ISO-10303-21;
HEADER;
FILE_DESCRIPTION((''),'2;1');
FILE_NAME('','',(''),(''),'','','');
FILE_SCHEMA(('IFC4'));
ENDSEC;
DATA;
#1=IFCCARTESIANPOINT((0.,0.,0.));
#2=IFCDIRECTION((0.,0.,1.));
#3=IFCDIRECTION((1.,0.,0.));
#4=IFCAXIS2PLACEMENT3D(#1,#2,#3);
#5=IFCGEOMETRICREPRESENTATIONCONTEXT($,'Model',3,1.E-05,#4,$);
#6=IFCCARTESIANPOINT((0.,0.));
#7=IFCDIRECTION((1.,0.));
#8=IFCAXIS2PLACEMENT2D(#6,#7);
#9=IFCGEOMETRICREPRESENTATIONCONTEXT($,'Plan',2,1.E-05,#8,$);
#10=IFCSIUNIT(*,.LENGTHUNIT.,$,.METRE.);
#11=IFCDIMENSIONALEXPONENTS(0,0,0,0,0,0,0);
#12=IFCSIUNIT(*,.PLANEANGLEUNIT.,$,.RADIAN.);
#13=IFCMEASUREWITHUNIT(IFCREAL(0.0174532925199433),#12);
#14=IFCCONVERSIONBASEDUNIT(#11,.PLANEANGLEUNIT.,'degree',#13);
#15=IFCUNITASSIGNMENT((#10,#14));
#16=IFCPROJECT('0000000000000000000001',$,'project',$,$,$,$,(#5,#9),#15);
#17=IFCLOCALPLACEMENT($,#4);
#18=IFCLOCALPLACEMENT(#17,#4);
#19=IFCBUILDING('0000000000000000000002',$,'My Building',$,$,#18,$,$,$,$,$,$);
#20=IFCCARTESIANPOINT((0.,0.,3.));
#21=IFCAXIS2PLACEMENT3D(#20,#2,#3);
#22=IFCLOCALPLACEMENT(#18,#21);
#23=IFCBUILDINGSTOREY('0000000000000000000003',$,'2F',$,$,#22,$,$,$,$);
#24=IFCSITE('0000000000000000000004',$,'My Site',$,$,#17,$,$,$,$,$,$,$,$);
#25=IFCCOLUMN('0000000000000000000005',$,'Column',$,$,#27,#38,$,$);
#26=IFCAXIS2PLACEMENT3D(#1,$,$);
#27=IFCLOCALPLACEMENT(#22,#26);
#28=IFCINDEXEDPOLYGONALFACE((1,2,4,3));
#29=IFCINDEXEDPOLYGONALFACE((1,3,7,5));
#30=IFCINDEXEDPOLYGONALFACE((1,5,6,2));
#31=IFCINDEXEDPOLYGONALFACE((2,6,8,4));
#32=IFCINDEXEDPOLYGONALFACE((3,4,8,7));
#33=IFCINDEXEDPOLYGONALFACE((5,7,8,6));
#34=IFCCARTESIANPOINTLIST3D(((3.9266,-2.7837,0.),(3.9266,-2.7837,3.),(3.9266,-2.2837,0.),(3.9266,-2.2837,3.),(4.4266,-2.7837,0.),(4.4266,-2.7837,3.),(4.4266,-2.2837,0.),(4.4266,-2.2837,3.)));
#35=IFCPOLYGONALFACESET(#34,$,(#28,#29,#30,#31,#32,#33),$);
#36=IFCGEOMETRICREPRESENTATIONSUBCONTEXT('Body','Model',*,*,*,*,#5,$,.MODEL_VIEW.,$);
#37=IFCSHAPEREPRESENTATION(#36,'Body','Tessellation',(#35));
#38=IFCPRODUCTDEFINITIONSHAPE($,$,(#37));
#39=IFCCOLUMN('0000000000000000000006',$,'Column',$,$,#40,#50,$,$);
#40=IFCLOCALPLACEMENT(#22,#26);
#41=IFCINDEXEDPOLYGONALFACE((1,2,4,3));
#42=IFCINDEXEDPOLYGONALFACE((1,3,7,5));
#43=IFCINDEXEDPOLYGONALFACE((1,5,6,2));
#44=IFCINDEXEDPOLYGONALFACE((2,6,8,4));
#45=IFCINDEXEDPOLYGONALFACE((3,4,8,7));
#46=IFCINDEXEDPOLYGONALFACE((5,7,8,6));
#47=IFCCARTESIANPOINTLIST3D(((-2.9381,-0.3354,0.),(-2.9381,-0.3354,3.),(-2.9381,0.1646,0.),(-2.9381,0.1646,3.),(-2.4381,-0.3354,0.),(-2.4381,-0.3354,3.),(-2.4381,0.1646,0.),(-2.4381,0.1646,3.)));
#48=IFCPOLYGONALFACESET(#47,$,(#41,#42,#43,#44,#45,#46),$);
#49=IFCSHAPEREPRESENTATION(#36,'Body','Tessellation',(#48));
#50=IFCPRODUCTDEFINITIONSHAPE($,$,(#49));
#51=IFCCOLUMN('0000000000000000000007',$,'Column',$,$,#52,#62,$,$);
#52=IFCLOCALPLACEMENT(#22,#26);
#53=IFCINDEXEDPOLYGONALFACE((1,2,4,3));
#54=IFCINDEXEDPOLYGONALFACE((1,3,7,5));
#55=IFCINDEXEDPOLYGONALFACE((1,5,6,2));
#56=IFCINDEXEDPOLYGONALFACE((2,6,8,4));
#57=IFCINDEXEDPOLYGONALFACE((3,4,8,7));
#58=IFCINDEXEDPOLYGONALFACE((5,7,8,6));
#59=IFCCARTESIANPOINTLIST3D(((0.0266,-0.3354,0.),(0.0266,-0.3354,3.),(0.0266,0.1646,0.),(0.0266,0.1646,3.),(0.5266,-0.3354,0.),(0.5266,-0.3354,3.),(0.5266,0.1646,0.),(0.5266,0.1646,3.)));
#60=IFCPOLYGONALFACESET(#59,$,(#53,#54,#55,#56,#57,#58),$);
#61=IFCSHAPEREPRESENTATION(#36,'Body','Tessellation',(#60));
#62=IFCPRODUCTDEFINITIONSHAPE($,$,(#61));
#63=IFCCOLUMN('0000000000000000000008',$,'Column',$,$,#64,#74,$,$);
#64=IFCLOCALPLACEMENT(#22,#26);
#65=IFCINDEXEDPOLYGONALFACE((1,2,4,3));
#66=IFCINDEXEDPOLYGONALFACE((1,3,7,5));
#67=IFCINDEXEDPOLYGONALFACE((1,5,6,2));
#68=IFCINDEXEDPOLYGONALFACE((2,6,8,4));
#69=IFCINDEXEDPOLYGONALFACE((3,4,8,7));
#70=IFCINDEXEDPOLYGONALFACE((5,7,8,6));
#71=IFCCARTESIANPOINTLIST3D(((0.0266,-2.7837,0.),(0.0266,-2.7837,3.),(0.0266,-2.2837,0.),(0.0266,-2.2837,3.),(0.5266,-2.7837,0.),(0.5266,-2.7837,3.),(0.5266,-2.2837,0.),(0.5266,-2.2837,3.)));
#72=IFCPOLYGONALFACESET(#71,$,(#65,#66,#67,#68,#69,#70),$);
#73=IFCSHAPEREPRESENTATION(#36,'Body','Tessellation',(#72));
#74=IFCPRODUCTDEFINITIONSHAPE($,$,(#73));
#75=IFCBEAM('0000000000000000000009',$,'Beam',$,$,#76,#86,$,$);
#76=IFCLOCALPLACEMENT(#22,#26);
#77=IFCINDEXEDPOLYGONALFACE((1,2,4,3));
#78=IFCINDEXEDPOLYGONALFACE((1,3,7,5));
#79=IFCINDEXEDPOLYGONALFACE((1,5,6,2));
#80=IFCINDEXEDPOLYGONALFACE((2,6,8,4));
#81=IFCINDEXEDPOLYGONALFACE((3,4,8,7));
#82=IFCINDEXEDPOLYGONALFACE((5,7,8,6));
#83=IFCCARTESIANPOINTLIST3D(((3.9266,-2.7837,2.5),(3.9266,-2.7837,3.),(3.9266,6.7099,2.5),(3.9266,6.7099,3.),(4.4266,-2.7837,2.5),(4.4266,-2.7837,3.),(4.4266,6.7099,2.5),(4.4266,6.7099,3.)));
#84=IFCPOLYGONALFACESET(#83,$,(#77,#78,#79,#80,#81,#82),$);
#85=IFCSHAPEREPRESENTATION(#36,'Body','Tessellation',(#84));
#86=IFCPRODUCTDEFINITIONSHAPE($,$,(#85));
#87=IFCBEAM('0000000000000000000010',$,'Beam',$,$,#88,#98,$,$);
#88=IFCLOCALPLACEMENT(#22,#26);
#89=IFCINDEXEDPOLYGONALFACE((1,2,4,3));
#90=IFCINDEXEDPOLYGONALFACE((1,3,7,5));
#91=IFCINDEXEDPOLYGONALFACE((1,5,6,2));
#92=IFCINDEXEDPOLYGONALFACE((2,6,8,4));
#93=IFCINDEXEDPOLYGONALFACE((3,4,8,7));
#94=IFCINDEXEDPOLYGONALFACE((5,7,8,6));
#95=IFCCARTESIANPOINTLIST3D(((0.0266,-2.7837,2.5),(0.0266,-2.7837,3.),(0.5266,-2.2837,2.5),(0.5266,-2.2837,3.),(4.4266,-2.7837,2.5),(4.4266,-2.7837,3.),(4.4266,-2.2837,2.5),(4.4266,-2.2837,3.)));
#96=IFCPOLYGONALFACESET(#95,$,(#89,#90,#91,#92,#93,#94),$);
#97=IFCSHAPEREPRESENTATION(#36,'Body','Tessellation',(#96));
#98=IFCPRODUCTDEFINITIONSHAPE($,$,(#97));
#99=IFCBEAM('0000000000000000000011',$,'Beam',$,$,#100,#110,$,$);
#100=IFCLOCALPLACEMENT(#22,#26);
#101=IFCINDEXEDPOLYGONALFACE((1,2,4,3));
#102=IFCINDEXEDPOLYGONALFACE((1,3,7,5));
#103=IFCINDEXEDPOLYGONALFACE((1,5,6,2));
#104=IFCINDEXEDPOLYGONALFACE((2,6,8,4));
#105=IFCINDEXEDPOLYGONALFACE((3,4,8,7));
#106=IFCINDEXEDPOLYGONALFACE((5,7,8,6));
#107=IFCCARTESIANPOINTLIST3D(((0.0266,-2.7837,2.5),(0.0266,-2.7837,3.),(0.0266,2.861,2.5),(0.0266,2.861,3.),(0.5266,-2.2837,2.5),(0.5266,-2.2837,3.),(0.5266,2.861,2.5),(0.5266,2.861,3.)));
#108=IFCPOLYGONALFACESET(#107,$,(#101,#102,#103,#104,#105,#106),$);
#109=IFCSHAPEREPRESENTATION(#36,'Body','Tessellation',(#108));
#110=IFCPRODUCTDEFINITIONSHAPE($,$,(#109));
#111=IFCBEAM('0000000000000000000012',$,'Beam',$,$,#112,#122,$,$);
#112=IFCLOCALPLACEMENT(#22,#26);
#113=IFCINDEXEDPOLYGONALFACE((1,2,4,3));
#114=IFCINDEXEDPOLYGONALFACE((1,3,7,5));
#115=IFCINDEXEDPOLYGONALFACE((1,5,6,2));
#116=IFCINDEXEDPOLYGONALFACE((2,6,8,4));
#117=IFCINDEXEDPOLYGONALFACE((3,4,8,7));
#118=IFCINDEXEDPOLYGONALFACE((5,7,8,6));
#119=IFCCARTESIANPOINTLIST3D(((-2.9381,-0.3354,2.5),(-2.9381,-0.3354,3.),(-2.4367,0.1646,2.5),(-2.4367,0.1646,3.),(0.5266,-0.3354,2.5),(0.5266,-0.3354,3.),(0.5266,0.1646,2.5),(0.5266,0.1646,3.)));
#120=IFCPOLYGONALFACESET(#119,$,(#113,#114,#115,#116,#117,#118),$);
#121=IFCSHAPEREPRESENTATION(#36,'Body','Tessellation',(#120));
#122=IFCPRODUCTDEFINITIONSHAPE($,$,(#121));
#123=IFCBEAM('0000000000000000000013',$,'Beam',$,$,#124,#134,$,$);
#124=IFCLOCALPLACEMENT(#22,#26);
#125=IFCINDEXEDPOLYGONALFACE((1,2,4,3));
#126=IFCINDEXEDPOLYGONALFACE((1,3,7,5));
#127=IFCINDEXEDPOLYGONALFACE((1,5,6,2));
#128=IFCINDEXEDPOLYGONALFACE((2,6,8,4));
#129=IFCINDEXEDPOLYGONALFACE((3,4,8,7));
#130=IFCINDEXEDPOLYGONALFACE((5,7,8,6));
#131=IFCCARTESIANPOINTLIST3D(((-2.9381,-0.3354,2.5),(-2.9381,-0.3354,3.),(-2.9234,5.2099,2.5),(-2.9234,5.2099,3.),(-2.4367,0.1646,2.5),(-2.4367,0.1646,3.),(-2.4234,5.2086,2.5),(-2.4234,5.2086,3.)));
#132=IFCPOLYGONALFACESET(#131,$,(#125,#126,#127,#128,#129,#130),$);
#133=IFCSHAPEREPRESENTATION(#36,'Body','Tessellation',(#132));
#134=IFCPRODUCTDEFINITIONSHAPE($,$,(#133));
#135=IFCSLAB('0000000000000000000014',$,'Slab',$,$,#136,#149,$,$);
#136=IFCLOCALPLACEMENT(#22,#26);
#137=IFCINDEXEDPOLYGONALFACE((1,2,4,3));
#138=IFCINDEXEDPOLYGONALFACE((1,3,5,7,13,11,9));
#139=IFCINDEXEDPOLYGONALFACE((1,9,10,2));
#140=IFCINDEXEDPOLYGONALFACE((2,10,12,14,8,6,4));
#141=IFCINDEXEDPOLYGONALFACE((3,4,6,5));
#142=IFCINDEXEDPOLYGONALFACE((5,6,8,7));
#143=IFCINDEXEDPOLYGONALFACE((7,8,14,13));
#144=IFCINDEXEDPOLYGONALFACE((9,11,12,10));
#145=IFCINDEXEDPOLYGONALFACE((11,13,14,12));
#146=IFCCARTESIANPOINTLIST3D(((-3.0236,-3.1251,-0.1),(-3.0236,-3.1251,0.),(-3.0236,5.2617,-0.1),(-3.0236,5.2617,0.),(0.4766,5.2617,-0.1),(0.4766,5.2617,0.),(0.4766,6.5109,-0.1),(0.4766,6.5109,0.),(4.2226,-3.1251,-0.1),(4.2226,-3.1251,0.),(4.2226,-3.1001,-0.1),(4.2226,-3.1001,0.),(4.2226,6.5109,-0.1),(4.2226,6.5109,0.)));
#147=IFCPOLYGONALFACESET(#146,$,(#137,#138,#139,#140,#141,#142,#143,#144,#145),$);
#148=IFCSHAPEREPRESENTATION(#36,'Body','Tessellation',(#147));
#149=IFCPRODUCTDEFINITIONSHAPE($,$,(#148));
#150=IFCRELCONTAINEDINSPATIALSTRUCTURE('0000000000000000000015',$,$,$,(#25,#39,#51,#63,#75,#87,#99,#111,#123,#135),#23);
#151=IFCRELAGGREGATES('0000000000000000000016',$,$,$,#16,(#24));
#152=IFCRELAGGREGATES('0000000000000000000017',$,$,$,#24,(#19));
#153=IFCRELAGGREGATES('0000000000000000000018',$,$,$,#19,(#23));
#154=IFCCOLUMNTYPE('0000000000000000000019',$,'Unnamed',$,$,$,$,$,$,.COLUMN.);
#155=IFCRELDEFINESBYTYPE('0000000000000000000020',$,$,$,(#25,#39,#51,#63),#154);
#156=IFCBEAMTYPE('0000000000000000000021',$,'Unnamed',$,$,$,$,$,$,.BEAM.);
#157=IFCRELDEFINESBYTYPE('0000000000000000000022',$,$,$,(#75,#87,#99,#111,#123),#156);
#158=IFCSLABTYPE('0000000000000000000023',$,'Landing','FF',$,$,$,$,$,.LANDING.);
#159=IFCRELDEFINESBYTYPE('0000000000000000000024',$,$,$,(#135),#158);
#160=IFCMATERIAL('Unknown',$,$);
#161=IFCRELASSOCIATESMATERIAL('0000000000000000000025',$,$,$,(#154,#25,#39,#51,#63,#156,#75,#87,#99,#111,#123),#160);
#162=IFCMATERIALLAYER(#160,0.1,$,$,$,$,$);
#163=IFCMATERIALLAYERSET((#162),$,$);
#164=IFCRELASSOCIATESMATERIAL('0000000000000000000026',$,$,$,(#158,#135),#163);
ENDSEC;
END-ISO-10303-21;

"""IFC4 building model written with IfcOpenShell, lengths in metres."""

from ifc_helpers import new_model, entity, si_unit, converted_unit, frame, origin_with_axes, origin_2d_with_axis, place, context, subcontext, project, spatial, indexed_curve, rectangle, outline, extrude, clip, halfspace, material, layer, layer_set, layer_usage, material_profile, profile_set, profile_usage, type_object, element, save


model = new_model("IFC4")

# Units and contexts
model_context = context("Model", 3, precision=1e-05, world=origin_with_axes())
plan_context = context("Plan", 2, precision=1e-05, world=origin_2d_with_axis())
body_context_1 = subcontext(model_context, "Body", "Model", "MODEL_VIEW")
ifc_project = project(units=[si_unit("LENGTHUNIT", "METRE"), converted_unit("PLANEANGLEUNIT", "degree", entity("IfcReal", 0.0174532925199433), si_unit("PLANEANGLEUNIT", "RADIAN"), dimensions=[0, 0, 0, 0, 0, 0, 0])], contexts=[model_context, plan_context])

# Site, building, storey
site_placement = place(None, origin_with_axes())
site = spatial("IfcSite", under=ifc_project, at=site_placement, Name="My Site")
building_placement = place(site_placement, origin_with_axes())
building = spatial("IfcBuilding", under=site, at=building_placement, Name="My Building")
storey_placement = place(building_placement, frame((0.0, 0.0, 3.0), z_axis=(0.0, 0.0, 1.0), x_axis=(1.0, 0.0, 0.0)))
storey = spatial("IfcBuildingStorey", under=building, at=storey_placement, Name="2F")

# Columns
ifc_material_1 = material(Name="Unknown")
ifc_material_profile_1 = material_profile(ifc_material_1, rectangle(XDim=0.5, YDim=0.5))
ifc_profile_set_1 = profile_set([ifc_material_profile_1])
ifc_profile_usage_1 = profile_usage(ifc_profile_set_1, cardinal=5)
column_type = type_object("IfcColumnType", Name="Unnamed", PredefinedType="COLUMN", material=ifc_profile_set_1)
column_1_placement = place(storey_placement, frame((4.1766, -2.5337, 0.0), z_axis=(0.0, 0.0, 1.0), x_axis=(1.0, 0.0, 0.0)))
element("IfcColumn", 1, at=column_1_placement, inside=storey, type_object=column_type, material=ifc_profile_usage_1, Name="Column", context=body_context_1, shape_type="SweptSolid", body=[
    extrude(rectangle(XDim=0.5, YDim=0.5), origin_with_axes(), (0.0, 0.0, 1.0), 3.0),
])
ifc_profile_usage_2 = profile_usage(ifc_profile_set_1, cardinal=5)
column_2_placement = place(storey_placement, frame((-2.6881, -0.0854, 0.0), z_axis=(0.0, 0.0, 1.0), x_axis=(1.0, 0.0, 0.0)))
element("IfcColumn", 2, at=column_2_placement, inside=storey, type_object=column_type, material=ifc_profile_usage_2, Name="Column", context=body_context_1, shape_type="SweptSolid", body=[
    extrude(rectangle(XDim=0.5, YDim=0.5), origin_with_axes(), (0.0, 0.0, 1.0), 3.0),
])
ifc_profile_usage_3 = profile_usage(ifc_profile_set_1, cardinal=5)
column_3_placement = place(storey_placement, frame((0.2766, -0.0854, 0.0), z_axis=(0.0, 0.0, 1.0), x_axis=(1.0, 0.0, 0.0)))
element("IfcColumn", 3, at=column_3_placement, inside=storey, type_object=column_type, material=ifc_profile_usage_3, Name="Column", context=body_context_1, shape_type="SweptSolid", body=[
    extrude(rectangle(XDim=0.5, YDim=0.5), origin_with_axes(), (0.0, 0.0, 1.0), 3.0),
])
ifc_profile_usage_4 = profile_usage(ifc_profile_set_1, cardinal=5)
column_4_placement = place(storey_placement, frame((0.2766, -2.5337, 0.0), z_axis=(0.0, 0.0, 1.0), x_axis=(1.0, 0.0, 0.0)))
element("IfcColumn", 4, at=column_4_placement, inside=storey, type_object=column_type, material=ifc_profile_usage_4, Name="Column", context=body_context_1, shape_type="SweptSolid", body=[
    extrude(rectangle(XDim=0.5, YDim=0.5), origin_with_axes(), (0.0, 0.0, 1.0), 3.0),
])

# Beams
ifc_material_profile_2 = material_profile(ifc_material_1, rectangle(XDim=0.5, YDim=0.5))
ifc_profile_set_2 = profile_set([ifc_material_profile_2])
ifc_profile_usage_5 = profile_usage(ifc_profile_set_2, cardinal=7)
beam_type = type_object("IfcBeamType", Name="Unnamed", PredefinedType="BEAM", material=ifc_profile_set_2)
beam_1_placement = place(storey_placement, frame((3.9266, -2.7837, 3.0), z_axis=(0.0, 1.0, 0.0), x_axis=(-1.0, 0.0, 0.0)))
element("IfcBeam", 5, at=beam_1_placement, inside=storey, type_object=beam_type, material=ifc_profile_usage_5, Name="Beam", context=body_context_1, shape_type="SweptSolid", body=[
    extrude(rectangle(XDim=0.5, YDim=0.5), frame((-0.25, -0.25, 0.0), z_axis=(0.0, 0.0, 1.0), x_axis=(1.0, 0.0, 0.0)), (0.0, 0.0, 1.0), 9.4936),
])
ifc_profile_usage_6 = profile_usage(ifc_profile_set_2, cardinal=7)
beam_2_placement = place(storey_placement, frame((4.4266, -2.7837, 3.0), z_axis=(-1.0, 0.0, 0.0), x_axis=(0.0, -1.0, 0.0)))
element("IfcBeam", 6, at=beam_2_placement, inside=storey, type_object=beam_type, material=ifc_profile_usage_6, Name="Beam", context=body_context_1, shape_type="Clipping", body=[
    clip(extrude(rectangle(XDim=0.5, YDim=0.5), frame((-0.25, -0.25, 0.0), z_axis=(0.0, 0.0, 1.0), x_axis=(1.0, 0.0, 0.0)), (0.0, 0.0, 1.0), 4.4), halfspace(frame((0.0, -6.0, 4.4), z_axis=(-0.707107, 0.0, 0.707107), x_axis=(0.0, 1.0, 0.0)), False)),
])
ifc_profile_usage_7 = profile_usage(ifc_profile_set_2, cardinal=7)
beam_3_placement = place(storey_placement, frame((0.0266, -2.7837, 3.0), z_axis=(0.0, 1.0, 0.0), x_axis=(-1.0, 0.0, 0.0)))
element("IfcBeam", 7, at=beam_3_placement, inside=storey, type_object=beam_type, material=ifc_profile_usage_7, Name="Beam", context=body_context_1, shape_type="Clipping", body=[
    clip(extrude(rectangle(XDim=0.5, YDim=0.5), frame((-0.25, -0.25, 0.0), z_axis=(0.0, 0.0, 1.0), x_axis=(1.0, 0.0, 0.0)), (0.0, 0.0, 1.0), 5.6448), halfspace(frame((0.0, -6.0, 0.0), z_axis=(-0.707107, 0.0, -0.707107), x_axis=(0.0, 1.0, 0.0)), False)),
])
ifc_profile_usage_8 = profile_usage(ifc_profile_set_2, cardinal=7)
beam_4_placement = place(storey_placement, frame((0.5266, -0.3354, 3.0), z_axis=(-1.0, 0.0, 0.0), x_axis=(0.0, -1.0, 0.0)))
element("IfcBeam", 8, at=beam_4_placement, inside=storey, type_object=beam_type, material=ifc_profile_usage_8, Name="Beam", context=body_context_1, shape_type="Clipping", body=[
    clip(extrude(rectangle(XDim=0.5, YDim=0.5), frame((-0.25, -0.25, 0.0), z_axis=(0.0, 0.0, 1.0), x_axis=(1.0, 0.0, 0.0)), (0.0, 0.0, 1.0), 3.9647), halfspace(frame((0.0, -6.0, 3.4647), z_axis=(-0.708041, 0.0, 0.706172), x_axis=(0.0, 1.0, 0.0)), False)),
])
ifc_profile_usage_9 = profile_usage(ifc_profile_set_2, cardinal=7)
beam_5_placement = place(storey_placement, frame((-2.9394, -0.8354, 3.0), z_axis=(0.002644, 0.999997, 0.0), x_axis=(-0.999997, 0.002644, 0.0)))
element("IfcBeam", 9, at=beam_5_placement, inside=storey, type_object=beam_type, material=ifc_profile_usage_9, Name="Beam", context=body_context_1, shape_type="Clipping", body=[
    clip(extrude(rectangle(XDim=0.5, YDim=0.5), frame((-0.25, -0.25, 0.0), z_axis=(0.0, 0.0, 1.0), x_axis=(1.0, 0.0, 0.0)), (0.0, 0.0, 1.0), 6.0453), halfspace(frame((0.0, -6.0, 0.5), z_axis=(-0.708042, 0.0, -0.706171), x_axis=(0.0, 1.0, 0.0)), False)),
])

# Slab
ifc_layer_1 = layer(ifc_material_1, 0.1)
ifc_layer_set_1 = layer_set([ifc_layer_1])
ifc_layer_usage_1 = layer_usage(ifc_layer_set_1, "AXIS3", "POSITIVE", -0.1)
slab_type = type_object("IfcSlabType", Name="Landing", Description="FF", PredefinedType="LANDING", material=ifc_layer_set_1)
slab_placement = place(storey_placement, frame((4.2226, -3.1001, 0.0), z_axis=(0.0, 0.0, 1.0), x_axis=(1.0, 0.0, 0.0)))
element("IfcSlab", 10, at=slab_placement, inside=storey, type_object=slab_type, material=ifc_layer_usage_1, Name="Slab", context=body_context_1, shape_type="SweptSolid", body=[
    extrude(outline(indexed_curve([(0.0, 0.0), (0.0, 9.611), (-3.746, 9.611), (-3.746, 8.3618), (-7.2462, 8.3618), (-7.2462, -0.025), (0.0, -0.025), (0.0, 0.0)])), frame((0.0, 0.0, -0.1), z_axis=(0.0, 0.0, 1.0), x_axis=(1.0, 0.0, 0.0)), (0.0, 0.0, 1.0), 0.1),
])

save(model, "model.ifc")
